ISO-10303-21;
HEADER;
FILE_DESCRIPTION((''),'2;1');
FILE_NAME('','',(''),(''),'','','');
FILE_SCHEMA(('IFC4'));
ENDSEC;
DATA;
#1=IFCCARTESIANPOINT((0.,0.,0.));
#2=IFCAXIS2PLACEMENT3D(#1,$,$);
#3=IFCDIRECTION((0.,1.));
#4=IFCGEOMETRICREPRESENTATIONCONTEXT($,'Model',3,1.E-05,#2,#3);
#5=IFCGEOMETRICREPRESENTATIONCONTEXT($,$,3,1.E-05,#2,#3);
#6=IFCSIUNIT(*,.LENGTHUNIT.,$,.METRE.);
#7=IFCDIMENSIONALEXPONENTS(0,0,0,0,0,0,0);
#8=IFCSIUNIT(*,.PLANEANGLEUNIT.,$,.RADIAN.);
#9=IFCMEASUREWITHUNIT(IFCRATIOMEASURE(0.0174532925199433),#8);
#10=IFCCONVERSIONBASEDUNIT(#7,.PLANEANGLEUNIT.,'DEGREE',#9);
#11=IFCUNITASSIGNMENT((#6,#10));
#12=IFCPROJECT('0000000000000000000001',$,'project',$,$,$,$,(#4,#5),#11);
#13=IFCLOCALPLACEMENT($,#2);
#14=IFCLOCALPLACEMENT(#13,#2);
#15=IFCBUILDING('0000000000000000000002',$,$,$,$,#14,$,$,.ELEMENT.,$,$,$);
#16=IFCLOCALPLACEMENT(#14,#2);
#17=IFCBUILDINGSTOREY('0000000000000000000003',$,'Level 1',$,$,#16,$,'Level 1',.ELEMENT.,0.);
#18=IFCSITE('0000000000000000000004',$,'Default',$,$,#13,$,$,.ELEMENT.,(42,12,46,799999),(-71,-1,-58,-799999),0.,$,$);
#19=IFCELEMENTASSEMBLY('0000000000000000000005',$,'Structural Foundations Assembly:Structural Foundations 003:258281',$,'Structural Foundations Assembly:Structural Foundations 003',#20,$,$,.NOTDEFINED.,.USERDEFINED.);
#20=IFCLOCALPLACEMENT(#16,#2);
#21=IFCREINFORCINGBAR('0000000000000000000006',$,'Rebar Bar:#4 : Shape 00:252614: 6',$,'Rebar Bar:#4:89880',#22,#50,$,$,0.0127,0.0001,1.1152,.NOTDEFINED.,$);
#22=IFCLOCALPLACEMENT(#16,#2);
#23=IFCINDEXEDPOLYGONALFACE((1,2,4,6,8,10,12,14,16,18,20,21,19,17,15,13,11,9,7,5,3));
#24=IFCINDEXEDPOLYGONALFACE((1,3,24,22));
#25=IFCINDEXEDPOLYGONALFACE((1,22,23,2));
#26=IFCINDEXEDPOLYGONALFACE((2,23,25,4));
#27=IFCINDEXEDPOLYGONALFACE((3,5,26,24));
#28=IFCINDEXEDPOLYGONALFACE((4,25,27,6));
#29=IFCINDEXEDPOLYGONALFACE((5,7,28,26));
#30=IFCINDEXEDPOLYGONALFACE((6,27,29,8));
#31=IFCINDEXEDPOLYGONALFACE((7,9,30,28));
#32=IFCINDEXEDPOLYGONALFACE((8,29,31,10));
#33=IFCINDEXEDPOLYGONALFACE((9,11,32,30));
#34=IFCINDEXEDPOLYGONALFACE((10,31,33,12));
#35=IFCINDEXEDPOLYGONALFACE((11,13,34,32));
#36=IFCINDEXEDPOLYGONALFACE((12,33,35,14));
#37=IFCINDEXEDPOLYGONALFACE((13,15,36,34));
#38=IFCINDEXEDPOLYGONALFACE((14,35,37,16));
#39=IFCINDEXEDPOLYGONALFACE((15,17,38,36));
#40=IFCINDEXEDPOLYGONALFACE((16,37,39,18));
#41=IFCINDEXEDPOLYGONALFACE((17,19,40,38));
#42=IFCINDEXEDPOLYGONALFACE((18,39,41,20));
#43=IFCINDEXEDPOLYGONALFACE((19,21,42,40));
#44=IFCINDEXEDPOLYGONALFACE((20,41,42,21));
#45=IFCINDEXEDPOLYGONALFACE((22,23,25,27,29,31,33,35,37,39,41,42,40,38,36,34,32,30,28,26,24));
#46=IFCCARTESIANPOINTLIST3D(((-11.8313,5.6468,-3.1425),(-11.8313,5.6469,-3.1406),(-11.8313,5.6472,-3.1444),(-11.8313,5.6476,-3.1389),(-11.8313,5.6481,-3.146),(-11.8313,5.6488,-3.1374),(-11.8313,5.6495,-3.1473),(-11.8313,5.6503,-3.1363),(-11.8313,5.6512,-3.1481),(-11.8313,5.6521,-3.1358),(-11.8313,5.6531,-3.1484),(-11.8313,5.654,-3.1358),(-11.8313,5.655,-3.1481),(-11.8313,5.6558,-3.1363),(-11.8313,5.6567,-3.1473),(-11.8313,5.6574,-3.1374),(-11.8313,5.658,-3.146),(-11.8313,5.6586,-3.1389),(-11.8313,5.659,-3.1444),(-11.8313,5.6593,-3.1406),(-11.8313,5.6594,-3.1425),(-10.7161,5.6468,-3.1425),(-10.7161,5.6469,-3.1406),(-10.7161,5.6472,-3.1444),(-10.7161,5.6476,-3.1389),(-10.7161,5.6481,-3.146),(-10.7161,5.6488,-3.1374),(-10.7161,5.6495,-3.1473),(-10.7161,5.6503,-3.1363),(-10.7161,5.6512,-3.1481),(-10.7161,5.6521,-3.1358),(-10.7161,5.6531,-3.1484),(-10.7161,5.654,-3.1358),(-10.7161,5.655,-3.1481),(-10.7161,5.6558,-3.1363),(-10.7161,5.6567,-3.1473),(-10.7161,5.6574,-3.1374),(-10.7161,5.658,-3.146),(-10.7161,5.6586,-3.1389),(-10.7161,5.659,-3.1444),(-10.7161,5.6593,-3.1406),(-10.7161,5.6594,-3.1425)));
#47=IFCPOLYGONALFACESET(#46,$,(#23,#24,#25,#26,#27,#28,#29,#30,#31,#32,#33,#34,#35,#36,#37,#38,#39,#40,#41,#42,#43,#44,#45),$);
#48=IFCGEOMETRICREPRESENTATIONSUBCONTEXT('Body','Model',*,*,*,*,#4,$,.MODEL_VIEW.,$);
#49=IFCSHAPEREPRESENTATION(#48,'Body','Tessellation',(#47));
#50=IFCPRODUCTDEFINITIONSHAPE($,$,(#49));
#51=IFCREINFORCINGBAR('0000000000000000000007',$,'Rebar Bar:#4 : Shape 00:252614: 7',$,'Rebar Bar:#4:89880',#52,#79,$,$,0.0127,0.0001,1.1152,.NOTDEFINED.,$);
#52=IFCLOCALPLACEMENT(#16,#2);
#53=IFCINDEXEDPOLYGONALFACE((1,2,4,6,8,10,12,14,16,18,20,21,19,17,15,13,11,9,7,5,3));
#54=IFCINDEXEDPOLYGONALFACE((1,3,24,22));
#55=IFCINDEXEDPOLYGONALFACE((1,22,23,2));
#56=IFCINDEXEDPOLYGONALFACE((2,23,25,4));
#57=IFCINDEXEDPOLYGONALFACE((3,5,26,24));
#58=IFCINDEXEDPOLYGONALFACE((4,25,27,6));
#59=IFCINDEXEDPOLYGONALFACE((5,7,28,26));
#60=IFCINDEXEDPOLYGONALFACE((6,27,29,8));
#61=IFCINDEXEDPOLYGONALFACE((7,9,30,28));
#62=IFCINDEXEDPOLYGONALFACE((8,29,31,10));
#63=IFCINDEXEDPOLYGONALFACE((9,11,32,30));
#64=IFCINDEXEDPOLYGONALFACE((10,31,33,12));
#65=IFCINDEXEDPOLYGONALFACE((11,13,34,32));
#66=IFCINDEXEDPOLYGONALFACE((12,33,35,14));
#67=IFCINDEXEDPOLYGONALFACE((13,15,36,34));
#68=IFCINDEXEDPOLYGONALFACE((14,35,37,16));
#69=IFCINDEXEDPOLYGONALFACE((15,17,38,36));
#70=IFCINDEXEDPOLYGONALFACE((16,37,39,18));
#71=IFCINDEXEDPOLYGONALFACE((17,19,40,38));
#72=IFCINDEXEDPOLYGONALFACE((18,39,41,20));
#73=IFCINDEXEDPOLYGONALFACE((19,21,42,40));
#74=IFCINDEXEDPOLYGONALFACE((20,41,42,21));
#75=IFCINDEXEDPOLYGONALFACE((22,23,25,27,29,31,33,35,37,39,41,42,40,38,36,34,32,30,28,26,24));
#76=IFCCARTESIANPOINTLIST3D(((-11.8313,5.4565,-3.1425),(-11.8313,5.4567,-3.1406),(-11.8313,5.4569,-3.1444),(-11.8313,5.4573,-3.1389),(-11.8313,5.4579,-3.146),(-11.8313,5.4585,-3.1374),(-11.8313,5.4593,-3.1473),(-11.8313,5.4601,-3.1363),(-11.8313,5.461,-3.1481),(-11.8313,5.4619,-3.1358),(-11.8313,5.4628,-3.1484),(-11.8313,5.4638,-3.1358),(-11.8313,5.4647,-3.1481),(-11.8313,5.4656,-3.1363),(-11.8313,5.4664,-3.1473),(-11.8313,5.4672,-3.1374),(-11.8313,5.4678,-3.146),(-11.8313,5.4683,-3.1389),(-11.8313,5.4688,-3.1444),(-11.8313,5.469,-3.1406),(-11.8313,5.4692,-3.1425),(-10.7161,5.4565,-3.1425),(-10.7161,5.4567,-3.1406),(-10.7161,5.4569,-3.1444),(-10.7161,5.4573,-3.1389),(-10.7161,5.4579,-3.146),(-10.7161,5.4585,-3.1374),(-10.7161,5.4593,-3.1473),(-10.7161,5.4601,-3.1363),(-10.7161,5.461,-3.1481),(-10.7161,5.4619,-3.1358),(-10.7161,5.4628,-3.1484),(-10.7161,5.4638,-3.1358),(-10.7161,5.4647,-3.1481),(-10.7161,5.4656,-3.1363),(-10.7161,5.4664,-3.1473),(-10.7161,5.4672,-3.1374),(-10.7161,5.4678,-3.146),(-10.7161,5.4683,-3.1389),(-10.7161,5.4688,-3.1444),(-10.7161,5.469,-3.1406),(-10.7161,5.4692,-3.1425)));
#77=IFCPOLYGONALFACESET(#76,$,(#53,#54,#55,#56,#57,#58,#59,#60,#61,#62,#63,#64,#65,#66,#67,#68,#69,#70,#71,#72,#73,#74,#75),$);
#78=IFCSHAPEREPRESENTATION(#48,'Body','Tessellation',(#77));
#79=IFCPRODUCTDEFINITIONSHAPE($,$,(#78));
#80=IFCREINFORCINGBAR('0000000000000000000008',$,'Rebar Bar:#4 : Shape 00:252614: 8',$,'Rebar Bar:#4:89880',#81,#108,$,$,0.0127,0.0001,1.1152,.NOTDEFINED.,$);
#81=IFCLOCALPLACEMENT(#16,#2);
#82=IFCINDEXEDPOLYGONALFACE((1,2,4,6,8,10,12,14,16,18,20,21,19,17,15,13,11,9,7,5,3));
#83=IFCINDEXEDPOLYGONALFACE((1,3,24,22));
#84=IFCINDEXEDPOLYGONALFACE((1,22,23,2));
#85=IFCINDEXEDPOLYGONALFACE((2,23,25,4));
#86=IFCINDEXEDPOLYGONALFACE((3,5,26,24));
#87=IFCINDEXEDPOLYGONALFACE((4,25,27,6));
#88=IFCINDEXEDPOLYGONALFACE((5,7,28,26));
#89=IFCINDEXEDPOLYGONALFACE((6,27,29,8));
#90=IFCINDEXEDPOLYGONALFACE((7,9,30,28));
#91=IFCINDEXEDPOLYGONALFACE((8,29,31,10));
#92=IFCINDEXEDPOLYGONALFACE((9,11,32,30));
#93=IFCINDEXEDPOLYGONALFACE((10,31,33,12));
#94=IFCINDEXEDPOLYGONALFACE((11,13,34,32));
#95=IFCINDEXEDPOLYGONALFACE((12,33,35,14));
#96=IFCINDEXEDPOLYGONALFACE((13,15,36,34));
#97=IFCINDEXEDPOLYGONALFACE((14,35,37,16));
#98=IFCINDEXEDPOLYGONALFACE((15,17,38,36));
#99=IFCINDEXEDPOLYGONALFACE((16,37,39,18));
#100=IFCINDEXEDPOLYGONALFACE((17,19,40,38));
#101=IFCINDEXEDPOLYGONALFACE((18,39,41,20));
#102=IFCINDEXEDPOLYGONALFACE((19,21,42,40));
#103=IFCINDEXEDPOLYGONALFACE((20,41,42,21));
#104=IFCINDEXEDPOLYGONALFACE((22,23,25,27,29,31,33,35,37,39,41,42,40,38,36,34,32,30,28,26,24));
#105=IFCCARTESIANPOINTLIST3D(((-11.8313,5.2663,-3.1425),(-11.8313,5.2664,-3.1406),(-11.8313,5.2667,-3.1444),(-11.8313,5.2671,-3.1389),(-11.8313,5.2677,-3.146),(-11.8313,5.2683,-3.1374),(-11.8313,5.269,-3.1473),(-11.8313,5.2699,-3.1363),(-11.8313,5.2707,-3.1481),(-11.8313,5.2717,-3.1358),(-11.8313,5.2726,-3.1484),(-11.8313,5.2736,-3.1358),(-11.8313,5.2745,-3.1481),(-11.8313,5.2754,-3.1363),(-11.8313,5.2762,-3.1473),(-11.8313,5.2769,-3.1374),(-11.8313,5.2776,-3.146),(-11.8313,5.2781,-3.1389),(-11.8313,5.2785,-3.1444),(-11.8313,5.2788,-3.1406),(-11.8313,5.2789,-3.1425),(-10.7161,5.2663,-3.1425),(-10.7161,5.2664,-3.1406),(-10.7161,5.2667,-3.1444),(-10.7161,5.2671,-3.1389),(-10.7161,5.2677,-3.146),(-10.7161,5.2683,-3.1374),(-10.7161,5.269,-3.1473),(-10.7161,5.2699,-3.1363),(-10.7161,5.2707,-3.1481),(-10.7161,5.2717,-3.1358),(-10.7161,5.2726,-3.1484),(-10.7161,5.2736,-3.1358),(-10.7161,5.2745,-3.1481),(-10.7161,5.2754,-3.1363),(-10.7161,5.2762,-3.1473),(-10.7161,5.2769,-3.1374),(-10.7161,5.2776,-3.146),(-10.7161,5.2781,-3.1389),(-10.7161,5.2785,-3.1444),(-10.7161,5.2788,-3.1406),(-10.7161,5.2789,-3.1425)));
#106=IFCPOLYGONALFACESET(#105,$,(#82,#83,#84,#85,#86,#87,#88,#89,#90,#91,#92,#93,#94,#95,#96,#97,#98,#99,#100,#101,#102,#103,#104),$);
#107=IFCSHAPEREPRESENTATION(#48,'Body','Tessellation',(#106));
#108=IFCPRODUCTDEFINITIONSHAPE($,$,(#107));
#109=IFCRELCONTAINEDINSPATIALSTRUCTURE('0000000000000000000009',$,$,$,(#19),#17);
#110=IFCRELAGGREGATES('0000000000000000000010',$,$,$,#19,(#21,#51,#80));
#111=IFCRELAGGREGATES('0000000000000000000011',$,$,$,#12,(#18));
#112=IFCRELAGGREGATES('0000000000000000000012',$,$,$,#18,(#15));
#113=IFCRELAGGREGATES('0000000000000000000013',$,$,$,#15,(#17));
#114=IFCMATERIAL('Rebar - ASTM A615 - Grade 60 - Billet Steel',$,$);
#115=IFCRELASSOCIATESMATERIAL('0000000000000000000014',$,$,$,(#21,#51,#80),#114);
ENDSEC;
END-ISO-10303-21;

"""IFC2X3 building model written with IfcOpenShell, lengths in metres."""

from ifc_helpers import new_model, entity, si_unit, converted_unit, direction, origin, place, context, subcontext, project, spatial, material, element, aggregate, save


model = new_model("IFC2X3")

# Units and contexts
model_context = context("Model", 3, precision=1e-05, world=origin(), true_north=direction((0.0, 1.0)))
context_of_model = context(None, 3, precision=1e-05, world=origin(), true_north=direction((0.0, 1.0)))
body_context = subcontext(model_context, "Body", "Model", "MODEL_VIEW")
ifc_project = project(units=[si_unit("LENGTHUNIT", "METRE"), converted_unit("PLANEANGLEUNIT", "DEGREE", entity("IfcRatioMeasure", 0.0174532925199433), si_unit("PLANEANGLEUNIT", "RADIAN"), dimensions=[0, 0, 0, 0, 0, 0, 0])], contexts=[model_context, context_of_model])

# Site, building, storey
site_placement = place(None, origin())
site = spatial("IfcSite", under=ifc_project, at=site_placement, Name="Default", CompositionType="ELEMENT", RefLatitude=(42, 12, 46, 799999), RefLongitude=(-71, -1, -58, -799999), RefElevation=0.0)
building_placement = place(site_placement, origin())
building = spatial("IfcBuilding", under=site, at=building_placement, CompositionType="ELEMENT")
storey_placement = place(building_placement, origin())
storey = spatial("IfcBuildingStorey", under=building, at=storey_placement, Name="Level 1", LongName="Level 1", CompositionType="ELEMENT", Elevation=0.0)

# Element assembly
assembly_1_placement = place(storey_placement, origin())
assembly_1 = element("IfcElementAssembly", 1, at=assembly_1_placement, inside=storey, Name="Structural Foundations Assembly:Structural Foundations 003:258281", ObjectType="Structural Foundations Assembly:Structural Foundations 003", AssemblyPlace="NOTDEFINED", PredefinedType="USERDEFINED")

# Shared definitions
ifc_material_1 = material(Name="Rebar - ASTM A615 - Grade 60 - Billet Steel")

# Reinforcing bars
reinforcing_bar_1_placement = place(assembly_1_placement, origin())
reinforcing_bar_1 = element("IfcReinforcingBar", 2, at=reinforcing_bar_1_placement, material=ifc_material_1, Name="Rebar Bar:#4 : Shape 00:252614: 6", ObjectType="Rebar Bar:#4:89880", BarLength=1.1152, BarRole="NOTDEFINED", CrossSectionArea=0.0001, NominalDiameter=0.0127, context=body_context, shape_type="AdvancedSweptSolid", body=[
    entity("IfcSweptDiskSolid", entity("IfcCompositeCurve", [entity("IfcCompositeCurveSegment", "CONTINUOUS", True, entity("IfcPolyline", [entity("IfcCartesianPoint", [-10.7161, 5.6531, -3.142]), entity("IfcCartesianPoint", [-11.8313, 5.6531, -3.142])]))], False), 0.0063, None, 0.0, 1.0),
])
reinforcing_bar_2_placement = place(assembly_1_placement, origin())
reinforcing_bar_2 = element("IfcReinforcingBar", 3, at=reinforcing_bar_2_placement, material=ifc_material_1, Name="Rebar Bar:#4 : Shape 00:252614: 7", ObjectType="Rebar Bar:#4:89880", BarLength=1.1152, BarRole="NOTDEFINED", CrossSectionArea=0.0001, NominalDiameter=0.0127, context=body_context, shape_type="AdvancedSweptSolid", body=[
    entity("IfcSweptDiskSolid", entity("IfcCompositeCurve", [entity("IfcCompositeCurveSegment", "CONTINUOUS", True, entity("IfcPolyline", [entity("IfcCartesianPoint", [-10.7161, 5.4628, -3.142]), entity("IfcCartesianPoint", [-11.8313, 5.4628, -3.142])]))], False), 0.0063, None, 0.0, 1.0),
])
reinforcing_bar_3_placement = place(assembly_1_placement, origin())
reinforcing_bar_3 = element("IfcReinforcingBar", 4, at=reinforcing_bar_3_placement, material=ifc_material_1, Name="Rebar Bar:#4 : Shape 00:252614: 8", ObjectType="Rebar Bar:#4:89880", BarLength=1.1152, BarRole="NOTDEFINED", CrossSectionArea=0.0001, NominalDiameter=0.0127, context=body_context, shape_type="AdvancedSweptSolid", body=[
    entity("IfcSweptDiskSolid", entity("IfcCompositeCurve", [entity("IfcCompositeCurveSegment", "CONTINUOUS", True, entity("IfcPolyline", [entity("IfcCartesianPoint", [-10.7161, 5.2726, -3.142]), entity("IfcCartesianPoint", [-11.8313, 5.2726, -3.142])]))], False), 0.0063, None, 0.0, 1.0),
])
aggregate(assembly_1, [reinforcing_bar_1, reinforcing_bar_2, reinforcing_bar_3])

save(model, "model.ifc")
